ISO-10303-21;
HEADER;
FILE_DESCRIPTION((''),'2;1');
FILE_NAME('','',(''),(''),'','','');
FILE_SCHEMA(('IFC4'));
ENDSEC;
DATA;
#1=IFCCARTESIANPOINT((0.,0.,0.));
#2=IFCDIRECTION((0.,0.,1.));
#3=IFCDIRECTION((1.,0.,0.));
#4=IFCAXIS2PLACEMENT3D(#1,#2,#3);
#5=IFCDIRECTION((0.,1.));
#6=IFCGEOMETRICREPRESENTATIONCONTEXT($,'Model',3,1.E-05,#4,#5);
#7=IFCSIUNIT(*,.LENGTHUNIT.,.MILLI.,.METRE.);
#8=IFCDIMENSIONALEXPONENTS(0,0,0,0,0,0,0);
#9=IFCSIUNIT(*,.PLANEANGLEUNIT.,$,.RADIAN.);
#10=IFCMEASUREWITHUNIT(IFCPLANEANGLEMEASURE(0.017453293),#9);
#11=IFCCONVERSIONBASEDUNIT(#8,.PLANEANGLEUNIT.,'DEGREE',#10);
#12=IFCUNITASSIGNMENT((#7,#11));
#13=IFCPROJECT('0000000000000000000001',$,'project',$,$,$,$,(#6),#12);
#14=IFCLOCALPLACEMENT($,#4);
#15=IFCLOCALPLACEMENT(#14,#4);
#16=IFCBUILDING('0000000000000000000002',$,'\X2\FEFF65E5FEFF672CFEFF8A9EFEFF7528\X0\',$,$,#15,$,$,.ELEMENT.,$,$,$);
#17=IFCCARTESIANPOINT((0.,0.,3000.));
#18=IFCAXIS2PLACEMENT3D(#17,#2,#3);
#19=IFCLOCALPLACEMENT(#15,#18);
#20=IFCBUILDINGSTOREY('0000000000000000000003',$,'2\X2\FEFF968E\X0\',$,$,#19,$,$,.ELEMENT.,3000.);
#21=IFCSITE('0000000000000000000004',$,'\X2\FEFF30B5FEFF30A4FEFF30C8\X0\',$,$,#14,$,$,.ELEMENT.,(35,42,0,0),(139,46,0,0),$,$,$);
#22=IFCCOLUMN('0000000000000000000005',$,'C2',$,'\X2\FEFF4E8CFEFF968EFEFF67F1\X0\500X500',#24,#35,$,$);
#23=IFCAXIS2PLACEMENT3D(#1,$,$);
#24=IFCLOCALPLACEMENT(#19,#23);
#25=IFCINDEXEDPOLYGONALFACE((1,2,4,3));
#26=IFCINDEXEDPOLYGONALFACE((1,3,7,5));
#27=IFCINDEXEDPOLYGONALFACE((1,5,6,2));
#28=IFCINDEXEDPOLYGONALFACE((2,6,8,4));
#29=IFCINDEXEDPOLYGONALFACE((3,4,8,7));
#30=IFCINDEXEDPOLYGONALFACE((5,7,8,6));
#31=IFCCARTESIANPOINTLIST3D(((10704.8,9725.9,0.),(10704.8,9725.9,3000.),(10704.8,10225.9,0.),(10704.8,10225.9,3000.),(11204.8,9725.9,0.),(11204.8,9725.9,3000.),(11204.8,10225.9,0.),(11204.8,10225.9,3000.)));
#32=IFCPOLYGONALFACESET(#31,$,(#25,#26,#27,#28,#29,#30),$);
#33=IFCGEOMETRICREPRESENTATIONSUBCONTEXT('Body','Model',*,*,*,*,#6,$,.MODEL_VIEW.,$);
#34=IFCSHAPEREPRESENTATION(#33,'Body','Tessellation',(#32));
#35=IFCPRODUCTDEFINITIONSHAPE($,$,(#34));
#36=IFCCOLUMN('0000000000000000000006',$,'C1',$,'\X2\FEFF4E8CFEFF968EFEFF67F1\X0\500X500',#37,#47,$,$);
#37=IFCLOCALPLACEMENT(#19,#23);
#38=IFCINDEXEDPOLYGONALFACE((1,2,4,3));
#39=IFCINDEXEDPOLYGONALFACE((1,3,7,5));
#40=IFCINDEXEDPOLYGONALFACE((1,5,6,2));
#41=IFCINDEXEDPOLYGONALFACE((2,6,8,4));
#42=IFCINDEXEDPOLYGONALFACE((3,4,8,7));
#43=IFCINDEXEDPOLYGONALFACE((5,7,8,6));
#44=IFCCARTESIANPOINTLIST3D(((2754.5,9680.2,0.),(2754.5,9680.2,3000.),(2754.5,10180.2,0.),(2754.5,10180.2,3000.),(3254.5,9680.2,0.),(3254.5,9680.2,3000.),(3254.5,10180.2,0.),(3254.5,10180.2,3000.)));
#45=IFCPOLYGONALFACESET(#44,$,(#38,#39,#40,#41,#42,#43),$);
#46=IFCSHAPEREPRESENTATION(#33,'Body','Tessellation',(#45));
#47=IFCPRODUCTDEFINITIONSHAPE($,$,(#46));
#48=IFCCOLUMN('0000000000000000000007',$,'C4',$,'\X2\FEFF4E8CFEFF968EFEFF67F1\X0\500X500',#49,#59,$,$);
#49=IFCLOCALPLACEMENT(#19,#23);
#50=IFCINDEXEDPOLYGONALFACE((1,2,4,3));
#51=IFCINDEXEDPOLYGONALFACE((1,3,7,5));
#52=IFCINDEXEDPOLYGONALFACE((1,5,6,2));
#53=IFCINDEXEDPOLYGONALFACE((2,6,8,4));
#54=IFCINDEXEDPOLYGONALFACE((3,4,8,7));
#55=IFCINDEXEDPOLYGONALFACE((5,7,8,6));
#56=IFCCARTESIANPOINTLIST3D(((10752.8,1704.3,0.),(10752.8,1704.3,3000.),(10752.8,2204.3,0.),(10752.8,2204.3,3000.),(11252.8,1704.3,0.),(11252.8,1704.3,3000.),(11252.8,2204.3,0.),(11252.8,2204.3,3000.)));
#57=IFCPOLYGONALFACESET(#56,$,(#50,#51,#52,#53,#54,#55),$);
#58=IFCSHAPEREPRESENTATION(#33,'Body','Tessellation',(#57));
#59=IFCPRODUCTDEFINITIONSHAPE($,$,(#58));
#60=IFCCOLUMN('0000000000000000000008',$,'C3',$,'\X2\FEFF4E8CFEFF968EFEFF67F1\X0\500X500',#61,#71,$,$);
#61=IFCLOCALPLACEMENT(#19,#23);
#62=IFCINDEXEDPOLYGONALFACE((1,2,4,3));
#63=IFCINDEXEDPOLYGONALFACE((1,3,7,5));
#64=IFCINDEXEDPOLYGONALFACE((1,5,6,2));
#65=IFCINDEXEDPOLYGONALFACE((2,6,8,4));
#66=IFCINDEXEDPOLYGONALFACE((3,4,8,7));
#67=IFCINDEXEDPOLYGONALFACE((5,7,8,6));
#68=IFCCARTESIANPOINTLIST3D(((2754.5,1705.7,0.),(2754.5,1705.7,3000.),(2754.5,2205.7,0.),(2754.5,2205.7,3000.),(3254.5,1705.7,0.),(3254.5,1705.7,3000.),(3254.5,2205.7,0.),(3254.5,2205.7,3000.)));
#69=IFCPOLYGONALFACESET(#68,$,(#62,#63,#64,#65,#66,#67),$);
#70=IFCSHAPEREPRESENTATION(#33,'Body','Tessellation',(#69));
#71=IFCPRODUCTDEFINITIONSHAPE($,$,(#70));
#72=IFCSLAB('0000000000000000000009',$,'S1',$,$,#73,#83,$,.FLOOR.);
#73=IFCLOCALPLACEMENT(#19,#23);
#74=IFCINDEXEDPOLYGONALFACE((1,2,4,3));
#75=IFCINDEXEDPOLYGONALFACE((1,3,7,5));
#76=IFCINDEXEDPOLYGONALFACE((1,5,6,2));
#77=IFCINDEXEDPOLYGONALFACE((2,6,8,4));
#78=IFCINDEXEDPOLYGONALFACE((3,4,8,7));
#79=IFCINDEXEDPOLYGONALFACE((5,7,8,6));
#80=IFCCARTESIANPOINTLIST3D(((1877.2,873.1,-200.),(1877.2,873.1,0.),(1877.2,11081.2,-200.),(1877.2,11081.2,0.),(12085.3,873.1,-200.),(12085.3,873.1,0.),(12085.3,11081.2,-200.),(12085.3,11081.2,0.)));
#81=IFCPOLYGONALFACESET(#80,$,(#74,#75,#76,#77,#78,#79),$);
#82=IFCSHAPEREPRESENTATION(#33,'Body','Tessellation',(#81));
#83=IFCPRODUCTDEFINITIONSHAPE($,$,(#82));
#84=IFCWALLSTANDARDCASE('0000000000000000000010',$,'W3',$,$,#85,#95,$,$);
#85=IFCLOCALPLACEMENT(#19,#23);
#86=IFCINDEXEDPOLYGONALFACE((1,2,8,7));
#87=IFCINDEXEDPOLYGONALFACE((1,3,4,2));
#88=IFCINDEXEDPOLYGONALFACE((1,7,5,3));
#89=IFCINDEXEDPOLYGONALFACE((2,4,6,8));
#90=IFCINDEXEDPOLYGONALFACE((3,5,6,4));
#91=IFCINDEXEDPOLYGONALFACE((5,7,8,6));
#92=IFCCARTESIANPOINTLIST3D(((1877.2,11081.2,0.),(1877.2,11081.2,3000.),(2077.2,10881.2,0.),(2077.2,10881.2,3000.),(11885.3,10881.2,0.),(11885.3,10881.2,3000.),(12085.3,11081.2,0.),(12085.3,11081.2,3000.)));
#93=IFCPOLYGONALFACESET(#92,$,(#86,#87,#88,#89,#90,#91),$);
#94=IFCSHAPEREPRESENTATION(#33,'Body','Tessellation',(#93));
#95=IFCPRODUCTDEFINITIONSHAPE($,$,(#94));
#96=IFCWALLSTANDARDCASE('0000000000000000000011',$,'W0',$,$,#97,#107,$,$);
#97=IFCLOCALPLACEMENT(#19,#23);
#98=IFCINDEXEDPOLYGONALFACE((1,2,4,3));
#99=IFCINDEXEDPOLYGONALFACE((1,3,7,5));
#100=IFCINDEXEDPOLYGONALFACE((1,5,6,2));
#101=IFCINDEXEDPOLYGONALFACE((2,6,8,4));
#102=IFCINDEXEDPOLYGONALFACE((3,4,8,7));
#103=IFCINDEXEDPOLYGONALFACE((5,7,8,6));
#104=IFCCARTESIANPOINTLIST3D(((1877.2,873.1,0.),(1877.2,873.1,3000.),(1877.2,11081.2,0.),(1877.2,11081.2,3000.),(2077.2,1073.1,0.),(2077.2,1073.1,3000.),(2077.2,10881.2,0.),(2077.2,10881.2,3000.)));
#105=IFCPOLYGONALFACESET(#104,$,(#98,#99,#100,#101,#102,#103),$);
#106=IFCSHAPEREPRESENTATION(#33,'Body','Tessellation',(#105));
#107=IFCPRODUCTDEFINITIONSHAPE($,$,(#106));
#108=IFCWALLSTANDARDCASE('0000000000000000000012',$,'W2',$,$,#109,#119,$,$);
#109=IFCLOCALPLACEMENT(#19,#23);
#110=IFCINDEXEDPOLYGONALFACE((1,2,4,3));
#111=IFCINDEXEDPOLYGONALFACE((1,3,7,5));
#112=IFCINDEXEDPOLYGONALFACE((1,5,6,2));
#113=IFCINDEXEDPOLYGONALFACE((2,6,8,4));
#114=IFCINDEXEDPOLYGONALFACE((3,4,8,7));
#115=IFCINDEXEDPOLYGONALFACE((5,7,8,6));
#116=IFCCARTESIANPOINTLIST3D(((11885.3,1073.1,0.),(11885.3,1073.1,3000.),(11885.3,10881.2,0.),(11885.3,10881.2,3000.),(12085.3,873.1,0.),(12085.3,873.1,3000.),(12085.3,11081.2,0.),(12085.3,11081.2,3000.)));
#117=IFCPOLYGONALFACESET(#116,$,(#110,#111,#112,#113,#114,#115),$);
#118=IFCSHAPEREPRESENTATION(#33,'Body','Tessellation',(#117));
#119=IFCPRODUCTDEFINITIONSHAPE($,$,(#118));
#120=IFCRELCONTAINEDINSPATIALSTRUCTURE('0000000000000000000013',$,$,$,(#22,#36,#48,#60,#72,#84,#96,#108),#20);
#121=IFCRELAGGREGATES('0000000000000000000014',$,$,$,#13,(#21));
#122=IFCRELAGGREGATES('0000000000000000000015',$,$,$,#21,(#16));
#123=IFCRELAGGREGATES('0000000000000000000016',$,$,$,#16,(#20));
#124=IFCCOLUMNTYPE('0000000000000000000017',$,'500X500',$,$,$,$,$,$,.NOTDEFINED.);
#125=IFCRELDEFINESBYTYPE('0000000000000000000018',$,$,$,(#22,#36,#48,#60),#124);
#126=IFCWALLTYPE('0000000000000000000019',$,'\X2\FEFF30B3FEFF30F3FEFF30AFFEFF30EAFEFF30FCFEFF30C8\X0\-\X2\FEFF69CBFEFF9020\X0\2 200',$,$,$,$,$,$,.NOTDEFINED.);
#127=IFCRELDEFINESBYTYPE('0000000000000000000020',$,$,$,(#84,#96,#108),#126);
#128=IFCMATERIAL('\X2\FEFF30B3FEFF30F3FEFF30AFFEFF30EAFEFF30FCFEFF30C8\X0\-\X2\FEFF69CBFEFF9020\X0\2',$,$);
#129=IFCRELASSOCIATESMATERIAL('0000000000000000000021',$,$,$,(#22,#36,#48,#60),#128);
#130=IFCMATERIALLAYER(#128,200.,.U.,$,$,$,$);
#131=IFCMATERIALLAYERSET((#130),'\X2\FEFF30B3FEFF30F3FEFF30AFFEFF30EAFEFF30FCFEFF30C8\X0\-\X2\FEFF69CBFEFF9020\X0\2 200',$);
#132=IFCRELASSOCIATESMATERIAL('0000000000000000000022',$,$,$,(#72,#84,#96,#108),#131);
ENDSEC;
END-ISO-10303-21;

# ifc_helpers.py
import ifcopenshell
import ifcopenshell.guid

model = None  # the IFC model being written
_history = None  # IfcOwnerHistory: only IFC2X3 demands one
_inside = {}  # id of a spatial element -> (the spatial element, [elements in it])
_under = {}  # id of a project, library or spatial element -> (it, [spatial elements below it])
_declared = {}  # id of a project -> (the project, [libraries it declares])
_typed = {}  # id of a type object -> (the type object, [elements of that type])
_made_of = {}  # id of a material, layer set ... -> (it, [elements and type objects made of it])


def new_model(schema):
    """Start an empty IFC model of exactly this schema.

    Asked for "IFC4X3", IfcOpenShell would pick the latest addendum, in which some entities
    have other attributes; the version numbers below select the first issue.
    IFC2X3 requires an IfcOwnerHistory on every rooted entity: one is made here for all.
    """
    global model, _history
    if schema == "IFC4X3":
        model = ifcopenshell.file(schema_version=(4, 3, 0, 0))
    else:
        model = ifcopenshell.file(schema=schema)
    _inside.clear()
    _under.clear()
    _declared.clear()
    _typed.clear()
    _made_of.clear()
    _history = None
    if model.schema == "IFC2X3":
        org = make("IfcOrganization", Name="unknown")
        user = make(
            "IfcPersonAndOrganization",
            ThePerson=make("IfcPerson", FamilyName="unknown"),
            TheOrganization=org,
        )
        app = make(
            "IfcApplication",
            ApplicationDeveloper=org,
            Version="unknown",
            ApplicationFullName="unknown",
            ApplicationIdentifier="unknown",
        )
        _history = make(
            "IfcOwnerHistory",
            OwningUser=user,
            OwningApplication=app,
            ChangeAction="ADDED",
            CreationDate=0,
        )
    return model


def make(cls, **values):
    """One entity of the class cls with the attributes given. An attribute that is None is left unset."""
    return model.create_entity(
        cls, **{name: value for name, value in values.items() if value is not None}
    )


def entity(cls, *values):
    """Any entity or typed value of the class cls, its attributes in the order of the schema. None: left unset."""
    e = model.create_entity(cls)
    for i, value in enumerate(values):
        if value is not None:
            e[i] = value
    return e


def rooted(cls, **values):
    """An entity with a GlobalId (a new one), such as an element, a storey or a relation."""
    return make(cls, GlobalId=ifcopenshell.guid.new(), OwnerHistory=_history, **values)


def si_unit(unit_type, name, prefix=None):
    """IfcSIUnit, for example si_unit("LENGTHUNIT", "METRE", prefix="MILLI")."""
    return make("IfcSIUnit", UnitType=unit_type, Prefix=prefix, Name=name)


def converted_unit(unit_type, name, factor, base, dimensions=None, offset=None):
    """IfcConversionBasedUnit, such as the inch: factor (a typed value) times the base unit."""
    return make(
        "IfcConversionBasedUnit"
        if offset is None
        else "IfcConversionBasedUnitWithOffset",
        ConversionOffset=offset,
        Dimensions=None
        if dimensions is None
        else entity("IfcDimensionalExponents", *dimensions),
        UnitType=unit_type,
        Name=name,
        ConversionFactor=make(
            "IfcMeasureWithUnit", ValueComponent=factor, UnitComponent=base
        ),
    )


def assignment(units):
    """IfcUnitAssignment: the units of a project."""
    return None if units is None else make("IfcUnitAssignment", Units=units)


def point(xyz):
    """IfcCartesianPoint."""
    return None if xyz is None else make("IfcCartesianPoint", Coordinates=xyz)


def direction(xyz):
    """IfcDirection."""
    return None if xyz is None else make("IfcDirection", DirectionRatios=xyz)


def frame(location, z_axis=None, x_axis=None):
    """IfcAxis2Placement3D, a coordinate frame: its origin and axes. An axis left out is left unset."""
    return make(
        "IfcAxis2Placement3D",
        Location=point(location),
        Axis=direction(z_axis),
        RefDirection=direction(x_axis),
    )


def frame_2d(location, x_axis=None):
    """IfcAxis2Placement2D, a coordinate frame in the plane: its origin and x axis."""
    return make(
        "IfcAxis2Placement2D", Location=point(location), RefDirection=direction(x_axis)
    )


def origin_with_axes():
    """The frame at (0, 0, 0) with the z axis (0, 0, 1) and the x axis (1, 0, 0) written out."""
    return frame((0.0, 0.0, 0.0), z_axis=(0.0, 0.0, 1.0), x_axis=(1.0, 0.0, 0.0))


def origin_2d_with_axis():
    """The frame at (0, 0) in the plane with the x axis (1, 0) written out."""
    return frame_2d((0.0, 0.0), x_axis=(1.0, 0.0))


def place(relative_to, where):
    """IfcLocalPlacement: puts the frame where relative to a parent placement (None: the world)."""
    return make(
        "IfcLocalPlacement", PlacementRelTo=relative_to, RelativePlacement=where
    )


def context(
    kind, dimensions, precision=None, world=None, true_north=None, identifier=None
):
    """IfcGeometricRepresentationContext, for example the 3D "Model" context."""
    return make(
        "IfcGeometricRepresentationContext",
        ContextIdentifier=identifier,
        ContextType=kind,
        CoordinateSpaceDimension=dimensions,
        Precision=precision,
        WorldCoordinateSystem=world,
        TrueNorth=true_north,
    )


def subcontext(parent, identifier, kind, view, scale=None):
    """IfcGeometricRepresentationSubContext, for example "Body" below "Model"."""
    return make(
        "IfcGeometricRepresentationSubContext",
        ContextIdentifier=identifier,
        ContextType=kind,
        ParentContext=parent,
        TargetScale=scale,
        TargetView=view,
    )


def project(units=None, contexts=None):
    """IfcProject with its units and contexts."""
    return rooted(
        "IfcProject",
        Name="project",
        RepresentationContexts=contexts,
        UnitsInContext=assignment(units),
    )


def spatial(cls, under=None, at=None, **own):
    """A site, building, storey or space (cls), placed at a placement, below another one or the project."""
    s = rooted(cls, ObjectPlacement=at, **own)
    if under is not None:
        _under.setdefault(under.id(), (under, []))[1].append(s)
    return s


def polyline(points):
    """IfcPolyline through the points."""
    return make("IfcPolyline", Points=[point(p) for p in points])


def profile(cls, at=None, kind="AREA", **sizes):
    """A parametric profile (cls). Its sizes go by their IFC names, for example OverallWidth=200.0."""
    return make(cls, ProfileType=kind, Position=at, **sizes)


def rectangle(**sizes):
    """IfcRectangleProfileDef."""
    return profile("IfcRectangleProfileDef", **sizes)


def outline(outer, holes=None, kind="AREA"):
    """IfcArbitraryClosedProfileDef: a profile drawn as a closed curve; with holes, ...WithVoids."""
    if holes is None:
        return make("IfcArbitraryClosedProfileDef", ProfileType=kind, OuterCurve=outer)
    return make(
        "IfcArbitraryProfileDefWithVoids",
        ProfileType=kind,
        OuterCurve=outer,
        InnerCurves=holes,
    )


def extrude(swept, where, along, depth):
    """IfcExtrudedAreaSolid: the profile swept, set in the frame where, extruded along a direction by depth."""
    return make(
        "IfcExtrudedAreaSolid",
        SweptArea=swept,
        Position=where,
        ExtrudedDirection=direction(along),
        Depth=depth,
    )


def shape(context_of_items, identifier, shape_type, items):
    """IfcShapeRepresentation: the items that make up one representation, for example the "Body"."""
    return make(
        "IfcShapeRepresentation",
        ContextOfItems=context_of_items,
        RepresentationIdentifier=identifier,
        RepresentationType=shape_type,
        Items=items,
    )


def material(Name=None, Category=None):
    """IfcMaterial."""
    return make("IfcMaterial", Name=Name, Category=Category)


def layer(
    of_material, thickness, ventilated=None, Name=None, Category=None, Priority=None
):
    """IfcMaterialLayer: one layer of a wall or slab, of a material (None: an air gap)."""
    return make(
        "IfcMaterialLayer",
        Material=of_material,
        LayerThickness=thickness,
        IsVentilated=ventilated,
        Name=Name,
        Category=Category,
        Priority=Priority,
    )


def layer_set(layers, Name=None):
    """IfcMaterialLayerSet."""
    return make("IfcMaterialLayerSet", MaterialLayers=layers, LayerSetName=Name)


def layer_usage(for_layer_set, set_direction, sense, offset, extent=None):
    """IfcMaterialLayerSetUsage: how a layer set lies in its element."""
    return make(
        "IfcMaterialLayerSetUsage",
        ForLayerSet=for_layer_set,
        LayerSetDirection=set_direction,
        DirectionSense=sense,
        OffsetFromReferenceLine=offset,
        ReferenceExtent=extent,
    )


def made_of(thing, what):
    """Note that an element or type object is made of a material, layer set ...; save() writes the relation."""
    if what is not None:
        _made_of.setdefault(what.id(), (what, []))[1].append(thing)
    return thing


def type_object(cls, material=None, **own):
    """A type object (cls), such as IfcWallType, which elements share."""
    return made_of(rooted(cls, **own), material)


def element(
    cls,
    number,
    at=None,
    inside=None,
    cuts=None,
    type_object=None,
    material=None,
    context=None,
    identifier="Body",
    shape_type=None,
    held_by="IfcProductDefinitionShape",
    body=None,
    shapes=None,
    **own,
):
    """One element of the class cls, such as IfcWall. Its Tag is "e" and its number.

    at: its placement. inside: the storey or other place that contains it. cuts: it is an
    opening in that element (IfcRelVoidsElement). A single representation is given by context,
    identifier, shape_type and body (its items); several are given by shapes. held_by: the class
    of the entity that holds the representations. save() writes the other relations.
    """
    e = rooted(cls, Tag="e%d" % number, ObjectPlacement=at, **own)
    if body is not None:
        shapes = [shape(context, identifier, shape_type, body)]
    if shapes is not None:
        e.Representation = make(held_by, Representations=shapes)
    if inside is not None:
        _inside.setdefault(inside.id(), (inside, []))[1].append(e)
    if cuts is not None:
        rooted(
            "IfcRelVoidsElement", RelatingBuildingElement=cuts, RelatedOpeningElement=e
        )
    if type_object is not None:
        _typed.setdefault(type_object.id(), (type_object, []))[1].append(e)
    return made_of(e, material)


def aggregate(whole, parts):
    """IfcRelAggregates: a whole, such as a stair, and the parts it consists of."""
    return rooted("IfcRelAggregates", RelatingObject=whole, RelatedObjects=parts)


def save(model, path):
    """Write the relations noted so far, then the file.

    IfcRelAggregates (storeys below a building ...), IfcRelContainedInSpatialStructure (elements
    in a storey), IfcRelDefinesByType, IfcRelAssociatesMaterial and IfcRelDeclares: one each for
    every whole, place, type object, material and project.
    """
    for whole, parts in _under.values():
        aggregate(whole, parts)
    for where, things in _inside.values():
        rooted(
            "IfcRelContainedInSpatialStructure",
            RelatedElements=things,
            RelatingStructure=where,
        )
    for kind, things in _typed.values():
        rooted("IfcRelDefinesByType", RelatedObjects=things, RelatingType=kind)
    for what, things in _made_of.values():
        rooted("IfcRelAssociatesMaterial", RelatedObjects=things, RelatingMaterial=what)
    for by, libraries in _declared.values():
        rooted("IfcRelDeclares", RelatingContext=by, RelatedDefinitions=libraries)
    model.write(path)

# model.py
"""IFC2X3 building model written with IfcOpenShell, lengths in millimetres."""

from ifc_helpers import new_model, entity, si_unit, converted_unit, direction, frame, origin_with_axes, origin_2d_with_axis, place, context, subcontext, project, spatial, polyline, rectangle, outline, extrude, material, layer, layer_set, layer_usage, type_object, element, save


model = new_model("IFC2X3")

# Units and contexts
model_context = context("Model", 3, precision=1e-05, world=origin_with_axes(), true_north=direction((0.0, 1.0)))
body_context = subcontext(model_context, "Body", "Model", "MODEL_VIEW")
ifc_project = project(units=[si_unit("LENGTHUNIT", "METRE", prefix="MILLI"), converted_unit("PLANEANGLEUNIT", "DEGREE", entity("IfcPlaneAngleMeasure", 0.017453293), si_unit("PLANEANGLEUNIT", "RADIAN"), dimensions=[0, 0, 0, 0, 0, 0, 0])], contexts=[model_context])

# Site, building, storey
site_placement = place(None, origin_with_axes())
site = spatial("IfcSite", under=ifc_project, at=site_placement, Name="\ufeffサ\ufeffイ\ufeffト", CompositionType="ELEMENT", RefLatitude=(35, 42, 0, 0), RefLongitude=(139, 46, 0, 0))
building_placement = place(site_placement, origin_with_axes())
building = spatial("IfcBuilding", under=site, at=building_placement, Name="\ufeff日\ufeff本\ufeff語\ufeff用", CompositionType="ELEMENT")
storey_placement = place(building_placement, frame((0.0, 0.0, 3000.0), z_axis=(0.0, 0.0, 1.0), x_axis=(1.0, 0.0, 0.0)))
storey = spatial("IfcBuildingStorey", under=building, at=storey_placement, Name="2\ufeff階", CompositionType="ELEMENT", Elevation=3000.0)

# Columns
ifc_material = material(Name="\ufeffコ\ufeffン\ufeffク\ufeffリ\ufeffー\ufeffト-\ufeff構\ufeff造2")
column_type = type_object("IfcColumnType", Name="500X500", PredefinedType="NOTDEFINED")
for number, where, z_axis, x_axis, name in (
    (1, (10954.8, 9975.9, 0.0), (0.0, 0.0, 1.0), (1.0, 0.0, 0.0), "C2"),
    (2, (3004.5, 9930.2, 0.0), (0.0, 0.0, 1.0), (1.0, 0.0, 0.0), "C1"),
    (3, (11002.8, 1954.3, 0.0), (0.0, 0.0, 1.0), (1.0, 0.0, 0.0), "C4"),
    (4, (3004.5, 1955.7, 0.0), (0.0, 0.0, 1.0), (1.0, 0.0, 0.0), "C3"),
):
    element("IfcColumn", number, at=place(storey_placement, frame(where, z_axis=z_axis, x_axis=x_axis)), inside=storey, type_object=column_type, material=ifc_material, Name=name, ObjectType="\ufeff二\ufeff階\ufeff柱500X500", context=body_context, shape_type="SweptSolid", body=[
        extrude(rectangle(XDim=500.0, YDim=500.0, at=origin_2d_with_axis()), origin_with_axes(), (0.0, 0.0, 1.0), 3000.0),
    ])

# Slab
ifc_layer = layer(ifc_material, 200.0, ventilated="UNKNOWN")
ifc_layer_set = layer_set([ifc_layer], Name="\ufeffコ\ufeffン\ufeffク\ufeffリ\ufeffー\ufeffト-\ufeff構\ufeff造2 200")
ifc_layer_usage_1 = layer_usage(ifc_layer_set, "AXIS3", "NEGATIVE", 200.0)
slab_1_placement = place(storey_placement, frame((1877.2, 11081.2, -200.0), z_axis=(0.0, 0.0, 1.0), x_axis=(1.0, 0.0, 0.0)))
element("IfcSlab", 5, at=slab_1_placement, inside=storey, material=ifc_layer_usage_1, Name="S1", PredefinedType="FLOOR", context=body_context, shape_type="SweptSolid", body=[
    extrude(outline(polyline([(0.0, 0.0), (0.0, -10208.1), (10208.1, -10208.1), (10208.1, 0.0), (0.0, 0.0)])), origin_with_axes(), (0.0, 0.0, 1.0), 200.0),
])

# Wall
ifc_layer_usage_2 = layer_usage(ifc_layer_set, "AXIS2", "NEGATIVE", 100.0)
wall_type = type_object("IfcWallType", Name="\ufeffコ\ufeffン\ufeffク\ufeffリ\ufeffー\ufeffト-\ufeff構\ufeff造2 200", PredefinedType="NOTDEFINED")
wall_1_placement = place(storey_placement, frame((11985.3, 10981.2, 0.0), z_axis=(0.0, 0.0, 1.0), x_axis=(-1.0, 0.0, 0.0)))
element("IfcWallStandardCase", 6, at=wall_1_placement, inside=storey, type_object=wall_type, material=ifc_layer_usage_2, Name="W3", context=body_context, shape_type="SweptSolid", body=[
    extrude(outline(polyline([(-100.0, -100.0), (10108.1, -100.0), (9908.1, 100.0), (100.0, 100.0), (-100.0, -100.0)])), origin_with_axes(), (0.0, 0.0, 1.0), 3000.0),
])

# Walls
ifc_layer_usage_3 = layer_usage(ifc_layer_set, "AXIS2", "NEGATIVE", 100.0)
wall_2_placement = place(storey_placement, frame((1977.2, 10981.2, 0.0), z_axis=(0.0, 0.0, 1.0), x_axis=(0.0, -1.0, 0.0)))
element("IfcWallStandardCase", 7, at=wall_2_placement, inside=storey, type_object=wall_type, material=ifc_layer_usage_3, Name="W0", context=body_context, shape_type="SweptSolid", body=[
    extrude(outline(polyline([(-100.0, -100.0), (10108.1, -100.0), (9908.1, 100.0), (100.0, 100.0), (-100.0, -100.0)])), origin_with_axes(), (0.0, 0.0, 1.0), 3000.0),
])
ifc_layer_usage_4 = layer_usage(ifc_layer_set, "AXIS2", "NEGATIVE", 100.0)
wall_3_placement = place(storey_placement, frame((11985.3, 973.1, 0.0), z_axis=(0.0, 0.0, 1.0), x_axis=(0.0, 1.0, 0.0)))
element("IfcWallStandardCase", 8, at=wall_3_placement, inside=storey, type_object=wall_type, material=ifc_layer_usage_4, Name="W2", context=body_context, shape_type="SweptSolid", body=[
    extrude(outline(polyline([(-100.0, -100.0), (10108.1, -100.0), (9908.1, 100.0), (100.0, 100.0), (-100.0, -100.0)])), origin_with_axes(), (0.0, 0.0, 1.0), 3000.0),
])

save(model, "model.ifc")
